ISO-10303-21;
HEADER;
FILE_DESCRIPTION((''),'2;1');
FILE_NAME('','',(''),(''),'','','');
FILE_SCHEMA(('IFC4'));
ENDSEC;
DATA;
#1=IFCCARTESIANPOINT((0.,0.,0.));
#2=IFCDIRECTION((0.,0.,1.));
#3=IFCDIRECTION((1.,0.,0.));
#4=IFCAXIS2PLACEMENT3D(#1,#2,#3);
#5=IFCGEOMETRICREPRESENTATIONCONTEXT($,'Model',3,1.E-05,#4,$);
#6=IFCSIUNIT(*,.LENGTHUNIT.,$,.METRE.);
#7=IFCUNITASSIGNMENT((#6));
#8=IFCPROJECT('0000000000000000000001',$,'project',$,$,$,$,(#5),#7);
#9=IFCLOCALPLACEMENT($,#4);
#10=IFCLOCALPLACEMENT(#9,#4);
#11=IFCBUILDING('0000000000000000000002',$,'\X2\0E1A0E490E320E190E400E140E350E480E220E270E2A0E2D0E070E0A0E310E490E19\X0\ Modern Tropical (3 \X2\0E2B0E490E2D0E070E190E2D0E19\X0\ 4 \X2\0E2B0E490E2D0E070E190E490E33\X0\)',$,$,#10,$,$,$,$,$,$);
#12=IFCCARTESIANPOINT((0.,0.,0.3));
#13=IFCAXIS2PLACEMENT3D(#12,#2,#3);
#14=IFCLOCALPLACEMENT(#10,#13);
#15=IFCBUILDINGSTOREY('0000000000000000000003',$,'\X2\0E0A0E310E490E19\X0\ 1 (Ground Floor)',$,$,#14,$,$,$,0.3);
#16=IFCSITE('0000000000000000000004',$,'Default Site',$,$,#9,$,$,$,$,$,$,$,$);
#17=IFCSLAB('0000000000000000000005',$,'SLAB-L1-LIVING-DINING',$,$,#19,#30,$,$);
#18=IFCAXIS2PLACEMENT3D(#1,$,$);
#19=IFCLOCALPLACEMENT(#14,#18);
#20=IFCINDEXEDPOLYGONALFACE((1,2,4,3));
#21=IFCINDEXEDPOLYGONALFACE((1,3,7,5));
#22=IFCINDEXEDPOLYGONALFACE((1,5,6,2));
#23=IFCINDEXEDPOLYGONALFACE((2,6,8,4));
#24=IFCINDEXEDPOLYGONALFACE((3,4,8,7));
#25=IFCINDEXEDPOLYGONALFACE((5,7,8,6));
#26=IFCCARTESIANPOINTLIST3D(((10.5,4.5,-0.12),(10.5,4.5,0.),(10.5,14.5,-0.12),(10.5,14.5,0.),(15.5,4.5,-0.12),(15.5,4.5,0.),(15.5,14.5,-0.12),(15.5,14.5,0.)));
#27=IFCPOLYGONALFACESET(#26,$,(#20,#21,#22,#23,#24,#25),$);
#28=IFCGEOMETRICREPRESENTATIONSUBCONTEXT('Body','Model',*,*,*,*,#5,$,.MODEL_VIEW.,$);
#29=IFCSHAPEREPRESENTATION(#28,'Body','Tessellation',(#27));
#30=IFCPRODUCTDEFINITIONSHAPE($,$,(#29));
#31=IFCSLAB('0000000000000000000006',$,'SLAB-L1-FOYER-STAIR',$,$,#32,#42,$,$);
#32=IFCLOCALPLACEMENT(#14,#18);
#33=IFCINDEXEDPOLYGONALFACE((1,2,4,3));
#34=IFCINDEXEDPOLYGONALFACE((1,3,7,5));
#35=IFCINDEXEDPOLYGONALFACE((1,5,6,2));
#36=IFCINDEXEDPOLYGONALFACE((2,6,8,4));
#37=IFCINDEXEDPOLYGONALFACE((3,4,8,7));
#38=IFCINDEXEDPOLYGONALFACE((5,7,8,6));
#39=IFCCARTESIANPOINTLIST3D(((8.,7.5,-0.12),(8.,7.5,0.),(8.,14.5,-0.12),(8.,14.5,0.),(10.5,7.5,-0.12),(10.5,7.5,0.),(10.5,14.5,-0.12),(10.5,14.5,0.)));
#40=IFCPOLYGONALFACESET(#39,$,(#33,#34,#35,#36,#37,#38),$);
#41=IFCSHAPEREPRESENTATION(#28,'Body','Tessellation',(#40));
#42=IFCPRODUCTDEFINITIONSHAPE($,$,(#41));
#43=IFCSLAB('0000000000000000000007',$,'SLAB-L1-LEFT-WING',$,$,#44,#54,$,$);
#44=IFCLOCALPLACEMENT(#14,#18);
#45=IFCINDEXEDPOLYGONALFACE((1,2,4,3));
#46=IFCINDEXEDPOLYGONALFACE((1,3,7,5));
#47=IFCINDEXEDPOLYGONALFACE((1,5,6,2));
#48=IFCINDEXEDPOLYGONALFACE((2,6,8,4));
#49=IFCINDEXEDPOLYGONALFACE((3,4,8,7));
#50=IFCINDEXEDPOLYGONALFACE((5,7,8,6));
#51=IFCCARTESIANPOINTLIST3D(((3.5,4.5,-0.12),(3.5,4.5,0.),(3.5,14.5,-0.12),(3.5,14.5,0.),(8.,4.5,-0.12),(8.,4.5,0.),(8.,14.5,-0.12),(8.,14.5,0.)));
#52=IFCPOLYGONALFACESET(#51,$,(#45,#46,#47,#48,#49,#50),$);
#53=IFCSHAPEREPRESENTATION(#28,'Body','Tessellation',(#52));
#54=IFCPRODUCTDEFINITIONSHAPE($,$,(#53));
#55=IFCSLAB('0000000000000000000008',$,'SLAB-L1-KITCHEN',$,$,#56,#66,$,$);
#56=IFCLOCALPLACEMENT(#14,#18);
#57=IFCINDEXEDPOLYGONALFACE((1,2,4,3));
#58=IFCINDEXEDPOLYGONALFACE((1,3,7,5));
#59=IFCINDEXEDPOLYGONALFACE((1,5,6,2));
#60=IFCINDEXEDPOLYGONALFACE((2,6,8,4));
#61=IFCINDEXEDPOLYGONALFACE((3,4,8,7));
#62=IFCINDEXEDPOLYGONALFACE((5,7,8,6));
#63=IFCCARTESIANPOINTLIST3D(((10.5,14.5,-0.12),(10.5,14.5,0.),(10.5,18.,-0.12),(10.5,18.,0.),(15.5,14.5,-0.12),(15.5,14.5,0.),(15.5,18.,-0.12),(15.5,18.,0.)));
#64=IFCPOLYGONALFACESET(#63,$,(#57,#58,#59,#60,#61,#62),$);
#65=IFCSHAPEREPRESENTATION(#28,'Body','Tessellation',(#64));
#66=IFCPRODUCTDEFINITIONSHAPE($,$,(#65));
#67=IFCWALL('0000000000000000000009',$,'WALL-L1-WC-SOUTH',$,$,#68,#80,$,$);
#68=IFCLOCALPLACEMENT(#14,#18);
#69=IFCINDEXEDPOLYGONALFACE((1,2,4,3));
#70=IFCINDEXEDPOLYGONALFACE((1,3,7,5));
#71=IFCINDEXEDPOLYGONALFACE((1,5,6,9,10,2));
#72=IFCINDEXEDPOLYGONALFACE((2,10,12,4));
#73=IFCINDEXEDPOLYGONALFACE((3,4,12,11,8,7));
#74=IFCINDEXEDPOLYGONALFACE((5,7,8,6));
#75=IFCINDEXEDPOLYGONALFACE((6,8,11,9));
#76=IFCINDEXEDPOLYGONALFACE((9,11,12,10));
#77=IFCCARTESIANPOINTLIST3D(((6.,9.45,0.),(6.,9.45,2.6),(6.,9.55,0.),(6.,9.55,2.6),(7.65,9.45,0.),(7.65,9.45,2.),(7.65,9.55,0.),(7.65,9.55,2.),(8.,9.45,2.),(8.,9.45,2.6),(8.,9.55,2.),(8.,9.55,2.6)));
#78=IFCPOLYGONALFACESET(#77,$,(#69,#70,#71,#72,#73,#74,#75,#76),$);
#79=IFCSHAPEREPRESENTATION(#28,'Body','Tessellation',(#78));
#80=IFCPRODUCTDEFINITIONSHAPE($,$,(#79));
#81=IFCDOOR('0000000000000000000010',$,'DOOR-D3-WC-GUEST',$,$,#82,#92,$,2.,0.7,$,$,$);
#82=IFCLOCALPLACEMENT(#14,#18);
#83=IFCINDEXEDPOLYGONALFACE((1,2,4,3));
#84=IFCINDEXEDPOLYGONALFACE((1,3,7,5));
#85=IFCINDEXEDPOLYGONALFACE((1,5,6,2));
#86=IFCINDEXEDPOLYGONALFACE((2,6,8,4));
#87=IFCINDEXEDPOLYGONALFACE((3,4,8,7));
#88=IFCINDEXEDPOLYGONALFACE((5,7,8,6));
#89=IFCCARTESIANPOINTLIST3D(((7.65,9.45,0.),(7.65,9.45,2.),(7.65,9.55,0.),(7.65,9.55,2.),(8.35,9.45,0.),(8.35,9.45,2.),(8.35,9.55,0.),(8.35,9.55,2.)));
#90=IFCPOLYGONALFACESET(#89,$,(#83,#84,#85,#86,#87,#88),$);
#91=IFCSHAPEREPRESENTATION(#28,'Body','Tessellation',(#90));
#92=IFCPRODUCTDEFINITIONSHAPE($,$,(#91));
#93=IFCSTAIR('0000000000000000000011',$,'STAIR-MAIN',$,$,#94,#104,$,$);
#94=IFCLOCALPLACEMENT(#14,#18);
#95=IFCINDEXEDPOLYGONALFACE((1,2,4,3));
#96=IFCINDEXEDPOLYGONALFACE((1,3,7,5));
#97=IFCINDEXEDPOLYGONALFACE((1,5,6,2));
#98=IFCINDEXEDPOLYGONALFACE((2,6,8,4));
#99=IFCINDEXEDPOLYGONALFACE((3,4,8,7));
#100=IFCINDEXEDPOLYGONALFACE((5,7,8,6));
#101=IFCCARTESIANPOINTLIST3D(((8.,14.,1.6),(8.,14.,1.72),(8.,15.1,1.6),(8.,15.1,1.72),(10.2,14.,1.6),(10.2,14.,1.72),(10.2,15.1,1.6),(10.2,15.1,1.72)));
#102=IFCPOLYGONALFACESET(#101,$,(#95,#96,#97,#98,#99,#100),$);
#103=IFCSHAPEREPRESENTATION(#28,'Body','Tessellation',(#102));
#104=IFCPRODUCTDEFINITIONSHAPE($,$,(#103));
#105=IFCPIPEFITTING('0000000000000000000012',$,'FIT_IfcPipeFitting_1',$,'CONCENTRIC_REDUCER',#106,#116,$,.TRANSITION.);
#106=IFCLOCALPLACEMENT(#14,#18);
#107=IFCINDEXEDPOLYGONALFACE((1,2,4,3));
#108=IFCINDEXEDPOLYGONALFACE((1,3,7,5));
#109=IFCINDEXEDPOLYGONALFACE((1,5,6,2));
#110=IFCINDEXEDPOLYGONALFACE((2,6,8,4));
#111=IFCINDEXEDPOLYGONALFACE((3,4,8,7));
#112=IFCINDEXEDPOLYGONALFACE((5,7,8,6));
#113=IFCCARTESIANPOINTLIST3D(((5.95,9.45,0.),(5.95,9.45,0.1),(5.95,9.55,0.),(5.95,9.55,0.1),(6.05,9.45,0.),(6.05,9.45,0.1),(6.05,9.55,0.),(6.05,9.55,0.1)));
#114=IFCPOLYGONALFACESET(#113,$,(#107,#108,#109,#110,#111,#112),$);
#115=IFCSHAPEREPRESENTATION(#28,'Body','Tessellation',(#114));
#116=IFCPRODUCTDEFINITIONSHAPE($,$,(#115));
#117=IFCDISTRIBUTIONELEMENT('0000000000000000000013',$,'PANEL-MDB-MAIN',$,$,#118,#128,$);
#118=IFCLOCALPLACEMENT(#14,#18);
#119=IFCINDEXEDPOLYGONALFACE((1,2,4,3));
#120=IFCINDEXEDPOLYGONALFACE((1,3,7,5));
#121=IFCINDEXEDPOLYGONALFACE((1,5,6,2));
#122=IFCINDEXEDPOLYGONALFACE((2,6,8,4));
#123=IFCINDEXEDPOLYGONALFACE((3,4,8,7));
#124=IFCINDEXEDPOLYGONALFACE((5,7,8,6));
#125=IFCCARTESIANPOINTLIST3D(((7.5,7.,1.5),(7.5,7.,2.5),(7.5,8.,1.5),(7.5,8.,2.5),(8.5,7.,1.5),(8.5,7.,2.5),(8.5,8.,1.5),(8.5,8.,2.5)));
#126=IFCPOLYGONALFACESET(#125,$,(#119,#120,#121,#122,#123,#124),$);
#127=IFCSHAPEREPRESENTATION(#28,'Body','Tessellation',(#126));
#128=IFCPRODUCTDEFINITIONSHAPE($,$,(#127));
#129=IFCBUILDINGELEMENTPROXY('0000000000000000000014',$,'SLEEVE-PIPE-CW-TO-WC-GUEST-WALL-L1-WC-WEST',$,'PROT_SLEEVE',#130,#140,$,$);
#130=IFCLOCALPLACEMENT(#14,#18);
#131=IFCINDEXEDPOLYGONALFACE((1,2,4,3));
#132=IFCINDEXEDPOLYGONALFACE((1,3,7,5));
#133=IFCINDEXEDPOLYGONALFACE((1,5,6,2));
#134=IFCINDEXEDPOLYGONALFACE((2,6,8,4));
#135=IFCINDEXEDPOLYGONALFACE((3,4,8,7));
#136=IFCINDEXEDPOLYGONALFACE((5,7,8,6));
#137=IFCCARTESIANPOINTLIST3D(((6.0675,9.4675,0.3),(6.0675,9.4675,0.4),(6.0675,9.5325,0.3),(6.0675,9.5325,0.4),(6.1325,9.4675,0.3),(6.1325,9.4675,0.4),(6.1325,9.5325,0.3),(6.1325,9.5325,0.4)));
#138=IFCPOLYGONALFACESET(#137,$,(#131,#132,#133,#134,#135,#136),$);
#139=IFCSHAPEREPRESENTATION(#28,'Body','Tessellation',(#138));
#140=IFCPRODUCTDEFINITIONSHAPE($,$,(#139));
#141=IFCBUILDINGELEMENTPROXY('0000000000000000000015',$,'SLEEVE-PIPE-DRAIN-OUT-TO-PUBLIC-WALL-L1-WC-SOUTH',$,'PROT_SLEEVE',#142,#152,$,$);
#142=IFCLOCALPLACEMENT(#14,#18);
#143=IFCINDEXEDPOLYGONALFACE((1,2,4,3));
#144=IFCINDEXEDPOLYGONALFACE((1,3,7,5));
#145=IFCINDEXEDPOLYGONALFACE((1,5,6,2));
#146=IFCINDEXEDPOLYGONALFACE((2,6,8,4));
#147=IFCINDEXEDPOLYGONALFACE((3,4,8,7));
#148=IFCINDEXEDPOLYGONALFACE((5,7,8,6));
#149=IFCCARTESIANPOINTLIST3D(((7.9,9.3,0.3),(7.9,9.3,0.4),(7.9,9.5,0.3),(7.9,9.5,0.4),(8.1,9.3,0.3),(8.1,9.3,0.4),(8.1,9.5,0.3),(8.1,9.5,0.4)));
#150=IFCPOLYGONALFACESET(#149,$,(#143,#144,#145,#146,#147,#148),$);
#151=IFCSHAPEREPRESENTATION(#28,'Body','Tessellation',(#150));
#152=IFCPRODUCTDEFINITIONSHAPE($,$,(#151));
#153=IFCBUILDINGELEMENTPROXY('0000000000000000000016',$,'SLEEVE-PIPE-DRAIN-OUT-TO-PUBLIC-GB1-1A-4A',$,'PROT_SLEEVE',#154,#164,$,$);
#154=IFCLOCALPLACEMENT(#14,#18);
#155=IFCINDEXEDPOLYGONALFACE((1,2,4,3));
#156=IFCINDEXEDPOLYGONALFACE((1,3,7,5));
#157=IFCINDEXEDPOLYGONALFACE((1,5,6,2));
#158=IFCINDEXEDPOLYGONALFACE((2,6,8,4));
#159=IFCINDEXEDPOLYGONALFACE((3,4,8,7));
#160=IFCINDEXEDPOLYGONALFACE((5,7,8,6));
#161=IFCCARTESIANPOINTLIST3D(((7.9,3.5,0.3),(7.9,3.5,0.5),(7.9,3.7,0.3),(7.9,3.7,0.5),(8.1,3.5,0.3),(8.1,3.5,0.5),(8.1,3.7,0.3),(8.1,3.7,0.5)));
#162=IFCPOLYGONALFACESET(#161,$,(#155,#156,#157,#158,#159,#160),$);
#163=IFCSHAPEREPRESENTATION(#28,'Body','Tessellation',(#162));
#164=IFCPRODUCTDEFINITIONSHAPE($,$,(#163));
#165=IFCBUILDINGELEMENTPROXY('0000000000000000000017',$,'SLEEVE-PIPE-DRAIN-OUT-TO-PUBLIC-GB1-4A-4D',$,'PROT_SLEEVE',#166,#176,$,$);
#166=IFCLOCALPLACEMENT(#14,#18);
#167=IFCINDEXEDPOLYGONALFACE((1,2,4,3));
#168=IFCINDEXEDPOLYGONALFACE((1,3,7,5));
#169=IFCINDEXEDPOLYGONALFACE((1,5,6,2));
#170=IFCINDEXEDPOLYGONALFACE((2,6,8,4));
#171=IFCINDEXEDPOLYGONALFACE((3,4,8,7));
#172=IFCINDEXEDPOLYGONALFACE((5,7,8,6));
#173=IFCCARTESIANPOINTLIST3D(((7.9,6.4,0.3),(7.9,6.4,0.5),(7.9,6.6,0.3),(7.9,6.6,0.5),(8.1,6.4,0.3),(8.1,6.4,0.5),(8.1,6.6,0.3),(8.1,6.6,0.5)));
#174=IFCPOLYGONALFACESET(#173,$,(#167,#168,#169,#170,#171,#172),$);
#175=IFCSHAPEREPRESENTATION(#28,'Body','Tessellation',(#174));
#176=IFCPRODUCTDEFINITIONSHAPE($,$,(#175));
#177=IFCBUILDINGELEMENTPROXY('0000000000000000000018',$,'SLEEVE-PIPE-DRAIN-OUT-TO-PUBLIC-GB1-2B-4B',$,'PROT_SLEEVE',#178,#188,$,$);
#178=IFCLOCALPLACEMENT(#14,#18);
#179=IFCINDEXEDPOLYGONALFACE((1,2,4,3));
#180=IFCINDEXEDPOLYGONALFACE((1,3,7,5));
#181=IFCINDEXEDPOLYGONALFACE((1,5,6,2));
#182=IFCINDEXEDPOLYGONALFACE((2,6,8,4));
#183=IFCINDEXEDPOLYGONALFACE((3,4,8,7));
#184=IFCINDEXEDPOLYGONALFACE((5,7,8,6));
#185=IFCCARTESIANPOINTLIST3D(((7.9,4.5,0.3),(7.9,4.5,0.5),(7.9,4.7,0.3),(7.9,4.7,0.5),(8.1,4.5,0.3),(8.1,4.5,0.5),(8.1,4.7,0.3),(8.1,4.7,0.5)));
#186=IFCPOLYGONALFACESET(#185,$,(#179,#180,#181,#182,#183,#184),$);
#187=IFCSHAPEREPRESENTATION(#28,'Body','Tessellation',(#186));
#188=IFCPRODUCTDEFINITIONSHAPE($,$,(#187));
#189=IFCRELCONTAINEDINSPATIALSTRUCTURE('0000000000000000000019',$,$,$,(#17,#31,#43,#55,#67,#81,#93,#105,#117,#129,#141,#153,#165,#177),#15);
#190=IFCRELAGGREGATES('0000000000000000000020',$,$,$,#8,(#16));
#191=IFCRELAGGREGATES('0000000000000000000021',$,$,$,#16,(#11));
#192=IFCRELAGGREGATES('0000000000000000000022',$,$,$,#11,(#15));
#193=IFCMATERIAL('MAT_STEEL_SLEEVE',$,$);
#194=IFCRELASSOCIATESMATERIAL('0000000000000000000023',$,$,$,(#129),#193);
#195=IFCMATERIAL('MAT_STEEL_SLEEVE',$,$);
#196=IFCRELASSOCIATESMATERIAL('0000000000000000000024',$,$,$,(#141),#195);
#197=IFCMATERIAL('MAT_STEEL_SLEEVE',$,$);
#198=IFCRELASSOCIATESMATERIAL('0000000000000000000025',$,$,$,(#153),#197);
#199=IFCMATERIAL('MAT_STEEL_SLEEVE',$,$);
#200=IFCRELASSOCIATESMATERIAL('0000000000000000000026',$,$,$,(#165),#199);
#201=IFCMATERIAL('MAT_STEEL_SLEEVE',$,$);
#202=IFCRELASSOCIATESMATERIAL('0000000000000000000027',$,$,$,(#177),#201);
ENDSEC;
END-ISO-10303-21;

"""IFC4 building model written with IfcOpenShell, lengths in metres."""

from ifc_helpers import new_model, si_unit, frame, origin_with_axes, origin_2d, place, context, subcontext, project, spatial, polyline, rectangle, outline, extrude, material, element, fill, save


model = new_model("IFC4")

# Units and contexts
model_context = context("Model", 3, precision=1e-05, world=origin_with_axes())
body_context = subcontext(model_context, "Body", "Model", "MODEL_VIEW")
ifc_project = project(units=[si_unit("LENGTHUNIT", "METRE")], contexts=[model_context])

# Site, building, storey
site_placement = place(None, origin_with_axes())
site = spatial("IfcSite", under=ifc_project, at=site_placement, Name="Default Site")
building_placement = place(site_placement, origin_with_axes())
building = spatial("IfcBuilding", under=site, at=building_placement, Name="บ้านเดี่ยวสองชั้น Modern Tropical (3 ห้องนอน 4 ห้องน้ำ)")
storey_placement = place(building_placement, frame((0.0, 0.0, 0.3), z_axis=(0.0, 0.0, 1.0), x_axis=(1.0, 0.0, 0.0)))
storey = spatial("IfcBuildingStorey", under=building, at=storey_placement, Name="ชั้น 1 (Ground Floor)", Elevation=0.3)

# Slabs
slab_1_placement = place(storey_placement, frame((0.0, 0.0, -0.12), z_axis=(0.0, 0.0, 1.0), x_axis=(1.0, 0.0, 0.0)))
element("IfcSlab", 1, at=slab_1_placement, inside=storey, Name="SLAB-L1-LIVING-DINING", context=body_context, shape_type="SweptSolid", body=[
    extrude(outline(polyline([(10.5, 4.5), (15.5, 4.5), (15.5, 14.5), (10.5, 14.5), (10.5, 4.5)])), origin_with_axes(), (0.0, 0.0, 1.0), 0.12),
])
slab_2_placement = place(storey_placement, frame((0.0, 0.0, -0.12), z_axis=(0.0, 0.0, 1.0), x_axis=(1.0, 0.0, 0.0)))
element("IfcSlab", 2, at=slab_2_placement, inside=storey, Name="SLAB-L1-FOYER-STAIR", context=body_context, shape_type="SweptSolid", body=[
    extrude(outline(polyline([(8.0, 7.5), (10.5, 7.5), (10.5, 14.5), (8.0, 14.5), (8.0, 7.5)])), origin_with_axes(), (0.0, 0.0, 1.0), 0.12),
])
slab_3_placement = place(storey_placement, frame((0.0, 0.0, -0.12), z_axis=(0.0, 0.0, 1.0), x_axis=(1.0, 0.0, 0.0)))
element("IfcSlab", 3, at=slab_3_placement, inside=storey, Name="SLAB-L1-LEFT-WING", context=body_context, shape_type="SweptSolid", body=[
    extrude(outline(polyline([(3.5, 4.5), (8.0, 4.5), (8.0, 14.5), (3.5, 14.5), (3.5, 4.5)])), origin_with_axes(), (0.0, 0.0, 1.0), 0.12),
])
slab_4_placement = place(storey_placement, frame((0.0, 0.0, -0.12), z_axis=(0.0, 0.0, 1.0), x_axis=(1.0, 0.0, 0.0)))
element("IfcSlab", 4, at=slab_4_placement, inside=storey, Name="SLAB-L1-KITCHEN", context=body_context, shape_type="SweptSolid", body=[
    extrude(outline(polyline([(10.5, 14.5), (15.5, 14.5), (15.5, 18.0), (10.5, 18.0), (10.5, 14.5)])), origin_with_axes(), (0.0, 0.0, 1.0), 0.12),
])

# Wall, opening, door
wall_placement = place(storey_placement, frame((7.0, 9.5, 0.0), z_axis=(0.0, 0.0, 1.0), x_axis=(1.0, 0.0, 0.0)))
wall = element("IfcWall", 5, at=wall_placement, inside=storey, Name="WALL-L1-WC-SOUTH", context=body_context, shape_type="SweptSolid", body=[
    extrude(rectangle(XDim=2.0, YDim=0.1, at=origin_2d()), origin_with_axes(), (0.0, 0.0, 1.0), 2.6),
])
opening_placement = place(wall_placement, frame((1.0, 0.0, 0.0), z_axis=(0.0, 0.0, 1.0), x_axis=(1.0, 0.0, 0.0)))
opening = element("IfcOpeningElement", 6, at=opening_placement, cuts=wall, context=body_context, shape_type="SweptSolid", body=[
    extrude(rectangle(XDim=0.7, YDim=0.12, at=origin_2d()), origin_with_axes(), (0.0, 0.0, 1.0), 2.0),
])
door_placement = place(opening_placement, origin_with_axes())
door = element("IfcDoor", 7, at=door_placement, inside=storey, Name="DOOR-D3-WC-GUEST", OverallHeight=2.0, OverallWidth=0.7, context=body_context, shape_type="SweptSolid", body=[
    extrude(rectangle(XDim=0.7, YDim=0.1, at=origin_2d()), origin_with_axes(), (0.0, 0.0, 1.0), 2.0),
])
fill(opening, door)

# Stair
stair_placement = place(storey_placement, frame((0.0, 0.0, 1.6), z_axis=(0.0, 0.0, 1.0), x_axis=(1.0, 0.0, 0.0)))
element("IfcStair", 8, at=stair_placement, inside=storey, Name="STAIR-MAIN", context=body_context, shape_type="SweptSolid", body=[
    extrude(outline(polyline([(8.0, 14.0), (10.2, 14.0), (10.2, 15.1), (8.0, 15.1), (8.0, 14.0)])), origin_with_axes(), (0.0, 0.0, 1.0), 0.12),
])

# Pipe fitting
pipe_fitting_placement = place(storey_placement, frame((6.0, 9.5, 0.0), z_axis=(0.0, 0.0, 1.0), x_axis=(1.0, 0.0, 0.0)))
element("IfcPipeFitting", 9, at=pipe_fitting_placement, inside=storey, Name="FIT_IfcPipeFitting_1", ObjectType="CONCENTRIC_REDUCER", PredefinedType="TRANSITION", context=body_context, shape_type="SweptSolid", body=[
    extrude(rectangle(XDim=0.1, YDim=0.1, at=origin_2d()), origin_with_axes(), (0.0, 0.0, 1.0), 0.1),
])

# Distribution element
distribution_element_placement = place(storey_placement, frame((8.0, 7.5, 1.5), z_axis=(0.0, 0.0, 1.0), x_axis=(1.0, 0.0, 0.0)))
element("IfcDistributionElement", 10, at=distribution_element_placement, inside=storey, Name="PANEL-MDB-MAIN", context=body_context, shape_type="SweptSolid", body=[
    extrude(rectangle(XDim=1.0, YDim=1.0, at=origin_2d()), origin_with_axes(), (0.0, 0.0, 1.0), 1.0),
])

# Building element proxies
ifc_material_1 = material(Name="MAT_STEEL_SLEEVE")
proxy_1_placement = place(storey_placement, frame((6.1, 9.5, 0.3), z_axis=(0.0, 0.0, 1.0), x_axis=(1.0, 0.0, 0.0)))
element("IfcBuildingElementProxy", 11, at=proxy_1_placement, inside=storey, material=ifc_material_1, Name="SLEEVE-PIPE-CW-TO-WC-GUEST-WALL-L1-WC-WEST", ObjectType="PROT_SLEEVE", context=body_context, shape_type="SweptSolid", body=[
    extrude(rectangle(XDim=0.065, YDim=0.065, at=origin_2d()), origin_with_axes(), (0.0, 0.0, 1.0), 0.1),
])
ifc_material_2 = material(Name="MAT_STEEL_SLEEVE")
proxy_2_placement = place(storey_placement, frame((8.0, 9.4, 0.3), z_axis=(0.0, 0.0, 1.0), x_axis=(1.0, 0.0, 0.0)))
element("IfcBuildingElementProxy", 12, at=proxy_2_placement, inside=storey, material=ifc_material_2, Name="SLEEVE-PIPE-DRAIN-OUT-TO-PUBLIC-WALL-L1-WC-SOUTH", ObjectType="PROT_SLEEVE", context=body_context, shape_type="SweptSolid", body=[
    extrude(rectangle(XDim=0.2, YDim=0.2, at=origin_2d()), origin_with_axes(), (0.0, 0.0, 1.0), 0.1),
])
ifc_material_3 = material(Name="MAT_STEEL_SLEEVE")
proxy_3_placement = place(storey_placement, frame((8.0, 3.6, 0.3), z_axis=(0.0, 0.0, 1.0), x_axis=(1.0, 0.0, 0.0)))
element("IfcBuildingElementProxy", 13, at=proxy_3_placement, inside=storey, material=ifc_material_3, Name="SLEEVE-PIPE-DRAIN-OUT-TO-PUBLIC-GB1-1A-4A", ObjectType="PROT_SLEEVE", context=body_context, shape_type="SweptSolid", body=[
    extrude(rectangle(XDim=0.2, YDim=0.2, at=origin_2d()), origin_with_axes(), (0.0, 0.0, 1.0), 0.2),
])
ifc_material_4 = material(Name="MAT_STEEL_SLEEVE")
proxy_4_placement = place(storey_placement, frame((8.0, 6.5, 0.3), z_axis=(0.0, 0.0, 1.0), x_axis=(1.0, 0.0, 0.0)))
element("IfcBuildingElementProxy", 14, at=proxy_4_placement, inside=storey, material=ifc_material_4, Name="SLEEVE-PIPE-DRAIN-OUT-TO-PUBLIC-GB1-4A-4D", ObjectType="PROT_SLEEVE", context=body_context, shape_type="SweptSolid", body=[
    extrude(rectangle(XDim=0.2, YDim=0.2, at=origin_2d()), origin_with_axes(), (0.0, 0.0, 1.0), 0.2),
])
ifc_material_5 = material(Name="MAT_STEEL_SLEEVE")
proxy_5_placement = place(storey_placement, frame((8.0, 4.6, 0.3), z_axis=(0.0, 0.0, 1.0), x_axis=(1.0, 0.0, 0.0)))
element("IfcBuildingElementProxy", 15, at=proxy_5_placement, inside=storey, material=ifc_material_5, Name="SLEEVE-PIPE-DRAIN-OUT-TO-PUBLIC-GB1-2B-4B", ObjectType="PROT_SLEEVE", context=body_context, shape_type="SweptSolid", body=[
    extrude(rectangle(XDim=0.2, YDim=0.2, at=origin_2d()), origin_with_axes(), (0.0, 0.0, 1.0), 0.2),
])

save(model, "model.ifc")
